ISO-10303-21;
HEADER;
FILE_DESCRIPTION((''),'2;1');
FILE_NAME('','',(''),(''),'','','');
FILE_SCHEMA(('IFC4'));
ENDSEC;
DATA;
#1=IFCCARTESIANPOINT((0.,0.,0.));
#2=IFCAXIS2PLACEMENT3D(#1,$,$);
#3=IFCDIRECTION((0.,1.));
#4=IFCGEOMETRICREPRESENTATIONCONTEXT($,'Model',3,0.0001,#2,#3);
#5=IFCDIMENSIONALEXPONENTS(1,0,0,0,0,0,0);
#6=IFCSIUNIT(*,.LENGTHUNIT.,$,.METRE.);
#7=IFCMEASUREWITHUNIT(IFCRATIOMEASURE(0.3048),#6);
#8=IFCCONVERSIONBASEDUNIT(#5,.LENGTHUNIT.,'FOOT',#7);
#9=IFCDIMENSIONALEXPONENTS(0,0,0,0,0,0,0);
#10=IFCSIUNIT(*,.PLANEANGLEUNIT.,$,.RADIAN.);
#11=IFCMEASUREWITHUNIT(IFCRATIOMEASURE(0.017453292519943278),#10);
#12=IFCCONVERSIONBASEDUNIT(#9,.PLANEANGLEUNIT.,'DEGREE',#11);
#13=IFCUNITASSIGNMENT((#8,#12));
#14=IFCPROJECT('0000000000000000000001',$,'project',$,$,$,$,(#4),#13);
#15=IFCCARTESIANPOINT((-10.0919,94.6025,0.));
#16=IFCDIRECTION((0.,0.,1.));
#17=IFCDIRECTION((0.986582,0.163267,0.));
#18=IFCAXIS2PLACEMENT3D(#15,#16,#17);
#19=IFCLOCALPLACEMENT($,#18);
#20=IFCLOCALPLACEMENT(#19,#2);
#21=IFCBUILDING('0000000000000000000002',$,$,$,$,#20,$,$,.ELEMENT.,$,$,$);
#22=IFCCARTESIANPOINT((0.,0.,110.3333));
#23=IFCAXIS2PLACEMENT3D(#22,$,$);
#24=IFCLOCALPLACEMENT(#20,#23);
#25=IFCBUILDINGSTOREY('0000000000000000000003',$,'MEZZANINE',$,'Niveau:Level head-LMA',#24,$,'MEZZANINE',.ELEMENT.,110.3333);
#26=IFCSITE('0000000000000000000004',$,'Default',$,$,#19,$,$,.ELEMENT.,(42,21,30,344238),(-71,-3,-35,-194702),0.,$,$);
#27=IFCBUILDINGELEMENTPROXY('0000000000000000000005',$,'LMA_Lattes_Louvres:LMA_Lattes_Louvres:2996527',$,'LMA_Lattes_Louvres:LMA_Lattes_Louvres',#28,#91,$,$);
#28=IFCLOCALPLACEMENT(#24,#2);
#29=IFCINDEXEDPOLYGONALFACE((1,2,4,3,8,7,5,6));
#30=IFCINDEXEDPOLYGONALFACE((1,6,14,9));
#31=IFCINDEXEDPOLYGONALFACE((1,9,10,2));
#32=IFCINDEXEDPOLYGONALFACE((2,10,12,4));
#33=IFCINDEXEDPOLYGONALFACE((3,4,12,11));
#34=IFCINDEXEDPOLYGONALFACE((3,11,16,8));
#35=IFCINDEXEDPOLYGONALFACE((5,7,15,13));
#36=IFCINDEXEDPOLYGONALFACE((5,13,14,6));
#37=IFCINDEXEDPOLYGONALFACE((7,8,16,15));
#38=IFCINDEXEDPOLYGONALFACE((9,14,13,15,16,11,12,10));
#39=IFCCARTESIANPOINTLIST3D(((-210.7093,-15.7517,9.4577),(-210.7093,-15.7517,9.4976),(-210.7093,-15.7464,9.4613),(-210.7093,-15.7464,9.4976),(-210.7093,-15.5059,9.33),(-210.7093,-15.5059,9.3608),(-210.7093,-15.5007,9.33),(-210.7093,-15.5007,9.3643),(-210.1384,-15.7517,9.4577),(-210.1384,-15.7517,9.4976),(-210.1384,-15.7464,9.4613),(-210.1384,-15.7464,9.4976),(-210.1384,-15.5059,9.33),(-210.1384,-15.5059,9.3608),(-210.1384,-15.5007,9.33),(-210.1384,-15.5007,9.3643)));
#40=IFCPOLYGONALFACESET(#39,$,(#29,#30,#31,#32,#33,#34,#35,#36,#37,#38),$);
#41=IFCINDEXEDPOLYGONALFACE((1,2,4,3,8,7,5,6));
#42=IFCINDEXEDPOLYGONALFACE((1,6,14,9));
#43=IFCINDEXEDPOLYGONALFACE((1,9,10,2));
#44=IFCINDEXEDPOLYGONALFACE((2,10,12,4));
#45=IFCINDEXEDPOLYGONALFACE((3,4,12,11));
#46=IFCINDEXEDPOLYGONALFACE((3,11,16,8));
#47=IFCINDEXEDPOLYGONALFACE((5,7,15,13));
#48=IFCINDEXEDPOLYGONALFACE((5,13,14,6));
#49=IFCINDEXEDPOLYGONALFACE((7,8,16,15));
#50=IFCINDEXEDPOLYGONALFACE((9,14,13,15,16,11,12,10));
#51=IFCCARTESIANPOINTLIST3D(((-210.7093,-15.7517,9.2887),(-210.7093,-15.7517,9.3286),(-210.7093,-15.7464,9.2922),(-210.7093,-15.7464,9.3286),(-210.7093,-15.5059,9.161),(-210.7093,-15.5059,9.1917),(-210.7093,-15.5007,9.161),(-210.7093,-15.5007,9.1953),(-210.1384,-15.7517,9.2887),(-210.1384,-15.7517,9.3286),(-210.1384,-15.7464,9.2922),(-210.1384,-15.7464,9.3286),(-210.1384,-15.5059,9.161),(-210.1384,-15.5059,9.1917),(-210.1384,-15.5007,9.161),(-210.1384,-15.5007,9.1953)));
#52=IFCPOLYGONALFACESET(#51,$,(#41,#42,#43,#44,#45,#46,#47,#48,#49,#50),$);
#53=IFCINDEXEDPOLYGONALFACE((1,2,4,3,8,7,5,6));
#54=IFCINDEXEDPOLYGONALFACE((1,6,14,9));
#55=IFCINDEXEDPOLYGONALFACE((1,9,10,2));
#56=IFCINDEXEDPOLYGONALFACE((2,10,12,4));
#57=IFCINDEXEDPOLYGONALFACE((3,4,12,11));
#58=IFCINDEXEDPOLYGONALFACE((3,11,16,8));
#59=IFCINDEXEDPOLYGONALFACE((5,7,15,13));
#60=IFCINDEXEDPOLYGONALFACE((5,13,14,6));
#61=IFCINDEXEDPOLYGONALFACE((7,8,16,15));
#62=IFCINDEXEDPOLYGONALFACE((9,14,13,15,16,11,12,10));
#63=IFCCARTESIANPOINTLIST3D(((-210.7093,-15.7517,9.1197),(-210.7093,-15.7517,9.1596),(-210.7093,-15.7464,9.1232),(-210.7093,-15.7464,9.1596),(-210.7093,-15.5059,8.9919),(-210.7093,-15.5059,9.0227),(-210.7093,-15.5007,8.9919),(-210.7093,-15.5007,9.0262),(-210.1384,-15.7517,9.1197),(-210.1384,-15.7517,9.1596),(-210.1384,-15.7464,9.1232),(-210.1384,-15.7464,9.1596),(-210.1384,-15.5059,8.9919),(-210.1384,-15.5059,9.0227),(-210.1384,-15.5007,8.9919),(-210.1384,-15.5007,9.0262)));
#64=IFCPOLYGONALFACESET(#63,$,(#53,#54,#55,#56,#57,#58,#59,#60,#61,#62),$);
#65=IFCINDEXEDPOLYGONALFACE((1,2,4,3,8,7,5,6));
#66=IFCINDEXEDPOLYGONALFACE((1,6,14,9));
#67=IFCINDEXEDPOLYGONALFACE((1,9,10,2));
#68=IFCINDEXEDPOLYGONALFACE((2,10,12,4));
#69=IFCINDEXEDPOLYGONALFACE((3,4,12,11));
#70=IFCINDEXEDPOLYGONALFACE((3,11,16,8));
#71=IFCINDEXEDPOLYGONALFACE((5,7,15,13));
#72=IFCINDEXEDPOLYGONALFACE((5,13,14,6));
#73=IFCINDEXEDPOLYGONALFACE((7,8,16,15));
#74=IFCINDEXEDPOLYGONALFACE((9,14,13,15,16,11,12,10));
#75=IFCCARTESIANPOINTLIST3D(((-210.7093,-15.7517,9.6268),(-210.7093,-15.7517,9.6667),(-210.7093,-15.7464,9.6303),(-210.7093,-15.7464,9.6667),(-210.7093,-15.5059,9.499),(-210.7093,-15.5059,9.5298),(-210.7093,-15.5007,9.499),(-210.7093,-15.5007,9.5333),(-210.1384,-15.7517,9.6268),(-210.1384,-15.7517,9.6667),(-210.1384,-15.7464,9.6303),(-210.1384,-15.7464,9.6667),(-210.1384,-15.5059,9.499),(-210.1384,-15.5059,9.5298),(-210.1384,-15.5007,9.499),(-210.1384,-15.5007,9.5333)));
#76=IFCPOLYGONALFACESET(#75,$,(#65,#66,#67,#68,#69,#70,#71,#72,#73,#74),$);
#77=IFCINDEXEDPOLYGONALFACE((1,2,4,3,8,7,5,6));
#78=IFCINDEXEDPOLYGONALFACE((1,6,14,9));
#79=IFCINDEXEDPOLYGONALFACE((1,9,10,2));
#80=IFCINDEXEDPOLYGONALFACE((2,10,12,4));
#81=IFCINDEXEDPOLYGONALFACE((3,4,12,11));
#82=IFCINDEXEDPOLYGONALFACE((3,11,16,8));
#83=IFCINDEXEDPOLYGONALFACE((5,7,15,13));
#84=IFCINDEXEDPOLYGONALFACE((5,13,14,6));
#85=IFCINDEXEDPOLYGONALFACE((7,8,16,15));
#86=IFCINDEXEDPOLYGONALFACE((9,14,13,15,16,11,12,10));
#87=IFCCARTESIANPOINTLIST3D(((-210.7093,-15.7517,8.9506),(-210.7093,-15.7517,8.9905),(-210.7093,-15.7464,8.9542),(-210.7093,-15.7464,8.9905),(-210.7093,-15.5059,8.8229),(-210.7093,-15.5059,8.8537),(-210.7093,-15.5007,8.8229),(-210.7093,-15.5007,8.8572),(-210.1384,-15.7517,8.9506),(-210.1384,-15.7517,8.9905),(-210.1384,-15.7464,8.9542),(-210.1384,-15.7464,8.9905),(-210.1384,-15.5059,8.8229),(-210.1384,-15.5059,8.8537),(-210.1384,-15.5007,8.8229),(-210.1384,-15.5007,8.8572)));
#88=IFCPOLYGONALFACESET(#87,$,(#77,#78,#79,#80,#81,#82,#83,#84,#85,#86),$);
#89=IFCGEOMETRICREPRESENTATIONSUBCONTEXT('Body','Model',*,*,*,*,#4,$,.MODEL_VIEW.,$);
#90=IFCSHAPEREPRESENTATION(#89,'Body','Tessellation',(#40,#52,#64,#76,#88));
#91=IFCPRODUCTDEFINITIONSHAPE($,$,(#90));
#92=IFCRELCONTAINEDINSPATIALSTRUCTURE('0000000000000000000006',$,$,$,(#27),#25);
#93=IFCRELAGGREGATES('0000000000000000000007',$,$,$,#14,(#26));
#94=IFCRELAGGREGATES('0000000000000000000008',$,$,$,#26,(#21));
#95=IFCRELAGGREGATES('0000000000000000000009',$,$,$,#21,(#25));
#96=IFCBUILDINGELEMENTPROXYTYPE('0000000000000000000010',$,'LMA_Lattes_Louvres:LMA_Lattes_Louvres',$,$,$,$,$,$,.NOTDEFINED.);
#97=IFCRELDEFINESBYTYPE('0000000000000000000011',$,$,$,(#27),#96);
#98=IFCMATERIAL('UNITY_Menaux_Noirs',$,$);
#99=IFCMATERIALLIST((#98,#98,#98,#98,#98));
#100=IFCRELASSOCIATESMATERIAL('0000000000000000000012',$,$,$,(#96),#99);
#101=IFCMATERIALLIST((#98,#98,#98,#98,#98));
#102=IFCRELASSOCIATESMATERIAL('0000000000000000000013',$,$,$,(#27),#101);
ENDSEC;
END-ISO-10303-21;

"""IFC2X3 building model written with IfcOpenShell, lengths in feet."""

from ifc_helpers import new_model, entity, si_unit, converted_unit, direction, frame, origin, place, context, subcontext, project, spatial, polyline, outline, extrude, source, transform, mapped, material, material_list, type_object, type_shapes, element, save


model = new_model("IFC2X3")

# Units and contexts
model_context = context("Model", 3, precision=0.0001, world=origin(), true_north=direction((0.0, 1.0)))
body_context = subcontext(model_context, "Body", "Model", "MODEL_VIEW")
ifc_project = project(units=[converted_unit("LENGTHUNIT", "FOOT", entity("IfcRatioMeasure", 0.3048), si_unit("LENGTHUNIT", "METRE"), dimensions=[1, 0, 0, 0, 0, 0, 0]), converted_unit("PLANEANGLEUNIT", "DEGREE", entity("IfcRatioMeasure", 0.017453292519943278), si_unit("PLANEANGLEUNIT", "RADIAN"), dimensions=[0, 0, 0, 0, 0, 0, 0])], contexts=[model_context])

# Site, building, storey
site_placement = place(None, frame((-10.0919, 94.6025, 0.0), z_axis=(0.0, 0.0, 1.0), x_axis=(0.986582, 0.163267, 0.0)))
site = spatial("IfcSite", under=ifc_project, at=site_placement, Name="Default", CompositionType="ELEMENT", RefLatitude=(42, 21, 30, 344238), RefLongitude=(-71, -3, -35, -194702), RefElevation=0.0)
building_placement = place(site_placement, origin())
building = spatial("IfcBuilding", under=site, at=building_placement, CompositionType="ELEMENT")
storey_placement = place(building_placement, frame((0.0, 0.0, 110.3333)))
storey = spatial("IfcBuildingStorey", under=building, at=storey_placement, Name="MEZZANINE", ObjectType="Niveau:Level head-LMA", LongName="MEZZANINE", CompositionType="ELEMENT", Elevation=110.3333)

# Building element proxy
ifc_material_1 = material(Name="UNITY_Menaux_Noirs")
ifc_material_list_1 = material_list([ifc_material_1, ifc_material_1, ifc_material_1, ifc_material_1, ifc_material_1])
ifc_material_list_2 = material_list([ifc_material_1, ifc_material_1, ifc_material_1, ifc_material_1, ifc_material_1])
building_element_proxy_type_1 = type_object("IfcBuildingElementProxyType", Name="LMA_Lattes_Louvres:LMA_Lattes_Louvres", PredefinedType="NOTDEFINED", material=ifc_material_list_2)
shared_shape_1 = source(origin(), body_context, "Body", "SweptSolid", [
    extrude(outline(polyline([(-0.1298, -0.0013), (0.1344, -0.0013), (0.147, 0.0306), (0.1421, 0.0325), (0.1308, 0.0039), (-0.1334, 0.0039), (-0.148, -0.0332), (-0.1432, -0.0351), (-0.1298, -0.0013)])), frame((-0.2854, -0.1255, 0.5895), z_axis=(1.0, 0.0, 0.0), x_axis=(0.0, -0.930221, -0.367)), (0.0, 0.0, 1.0), 0.5709),
    extrude(outline(polyline([(-0.1298, -0.0013), (0.1344, -0.0013), (0.147, 0.0306), (0.1421, 0.0325), (0.1308, 0.0039), (-0.1334, 0.0039), (-0.148, -0.0332), (-0.1432, -0.0351), (-0.1298, -0.0013)])), frame((-0.2854, -0.1255, 0.4205), z_axis=(1.0, 0.0, 0.0), x_axis=(0.0, -0.930221, -0.367)), (0.0, 0.0, 1.0), 0.5709),
    extrude(outline(polyline([(-0.1298, -0.0013), (0.1344, -0.0013), (0.147, 0.0306), (0.1421, 0.0325), (0.1308, 0.0039), (-0.1334, 0.0039), (-0.148, -0.0332), (-0.1432, -0.0351), (-0.1298, -0.0013)])), frame((-0.2854, -0.1255, 0.2514), z_axis=(1.0, 0.0, 0.0), x_axis=(0.0, -0.930221, -0.367)), (0.0, 0.0, 1.0), 0.5709),
    extrude(outline(polyline([(-0.1298, -0.0013), (0.1344, -0.0013), (0.147, 0.0306), (0.1421, 0.0325), (0.1308, 0.0039), (-0.1334, 0.0039), (-0.148, -0.0332), (-0.1432, -0.0351), (-0.1298, -0.0013)])), frame((-0.2854, -0.1255, 0.7585), z_axis=(1.0, 0.0, 0.0), x_axis=(0.0, -0.930221, -0.367)), (0.0, 0.0, 1.0), 0.5709),
    extrude(outline(polyline([(-0.1298, -0.0013), (0.1344, -0.0013), (0.147, 0.0306), (0.1421, 0.0325), (0.1308, 0.0039), (-0.1334, 0.0039), (-0.148, -0.0332), (-0.1432, -0.0351), (-0.1298, -0.0013)])), frame((-0.2854, -0.1255, 0.0824), z_axis=(1.0, 0.0, 0.0), x_axis=(0.0, -0.930221, -0.367)), (0.0, 0.0, 1.0), 0.5709),
])
type_shapes(building_element_proxy_type_1, [shared_shape_1])
proxy_1_placement = place(storey_placement, frame((-210.4238, -15.7517, 8.8229), z_axis=(0.0, 0.0, 1.0), x_axis=(-1.0, 0.0, 0.0)))
element("IfcBuildingElementProxy", 1, at=proxy_1_placement, inside=storey, type_object=building_element_proxy_type_1, material=ifc_material_list_1, Name="LMA_Lattes_Louvres:LMA_Lattes_Louvres:2996527", ObjectType="LMA_Lattes_Louvres:LMA_Lattes_Louvres", context=body_context, shape_type="MappedRepresentation", body=[
    mapped(shared_shape_1, transform((0.0, 0.0, 0.0), scale=1.0)),
])

save(model, "model.ifc")
